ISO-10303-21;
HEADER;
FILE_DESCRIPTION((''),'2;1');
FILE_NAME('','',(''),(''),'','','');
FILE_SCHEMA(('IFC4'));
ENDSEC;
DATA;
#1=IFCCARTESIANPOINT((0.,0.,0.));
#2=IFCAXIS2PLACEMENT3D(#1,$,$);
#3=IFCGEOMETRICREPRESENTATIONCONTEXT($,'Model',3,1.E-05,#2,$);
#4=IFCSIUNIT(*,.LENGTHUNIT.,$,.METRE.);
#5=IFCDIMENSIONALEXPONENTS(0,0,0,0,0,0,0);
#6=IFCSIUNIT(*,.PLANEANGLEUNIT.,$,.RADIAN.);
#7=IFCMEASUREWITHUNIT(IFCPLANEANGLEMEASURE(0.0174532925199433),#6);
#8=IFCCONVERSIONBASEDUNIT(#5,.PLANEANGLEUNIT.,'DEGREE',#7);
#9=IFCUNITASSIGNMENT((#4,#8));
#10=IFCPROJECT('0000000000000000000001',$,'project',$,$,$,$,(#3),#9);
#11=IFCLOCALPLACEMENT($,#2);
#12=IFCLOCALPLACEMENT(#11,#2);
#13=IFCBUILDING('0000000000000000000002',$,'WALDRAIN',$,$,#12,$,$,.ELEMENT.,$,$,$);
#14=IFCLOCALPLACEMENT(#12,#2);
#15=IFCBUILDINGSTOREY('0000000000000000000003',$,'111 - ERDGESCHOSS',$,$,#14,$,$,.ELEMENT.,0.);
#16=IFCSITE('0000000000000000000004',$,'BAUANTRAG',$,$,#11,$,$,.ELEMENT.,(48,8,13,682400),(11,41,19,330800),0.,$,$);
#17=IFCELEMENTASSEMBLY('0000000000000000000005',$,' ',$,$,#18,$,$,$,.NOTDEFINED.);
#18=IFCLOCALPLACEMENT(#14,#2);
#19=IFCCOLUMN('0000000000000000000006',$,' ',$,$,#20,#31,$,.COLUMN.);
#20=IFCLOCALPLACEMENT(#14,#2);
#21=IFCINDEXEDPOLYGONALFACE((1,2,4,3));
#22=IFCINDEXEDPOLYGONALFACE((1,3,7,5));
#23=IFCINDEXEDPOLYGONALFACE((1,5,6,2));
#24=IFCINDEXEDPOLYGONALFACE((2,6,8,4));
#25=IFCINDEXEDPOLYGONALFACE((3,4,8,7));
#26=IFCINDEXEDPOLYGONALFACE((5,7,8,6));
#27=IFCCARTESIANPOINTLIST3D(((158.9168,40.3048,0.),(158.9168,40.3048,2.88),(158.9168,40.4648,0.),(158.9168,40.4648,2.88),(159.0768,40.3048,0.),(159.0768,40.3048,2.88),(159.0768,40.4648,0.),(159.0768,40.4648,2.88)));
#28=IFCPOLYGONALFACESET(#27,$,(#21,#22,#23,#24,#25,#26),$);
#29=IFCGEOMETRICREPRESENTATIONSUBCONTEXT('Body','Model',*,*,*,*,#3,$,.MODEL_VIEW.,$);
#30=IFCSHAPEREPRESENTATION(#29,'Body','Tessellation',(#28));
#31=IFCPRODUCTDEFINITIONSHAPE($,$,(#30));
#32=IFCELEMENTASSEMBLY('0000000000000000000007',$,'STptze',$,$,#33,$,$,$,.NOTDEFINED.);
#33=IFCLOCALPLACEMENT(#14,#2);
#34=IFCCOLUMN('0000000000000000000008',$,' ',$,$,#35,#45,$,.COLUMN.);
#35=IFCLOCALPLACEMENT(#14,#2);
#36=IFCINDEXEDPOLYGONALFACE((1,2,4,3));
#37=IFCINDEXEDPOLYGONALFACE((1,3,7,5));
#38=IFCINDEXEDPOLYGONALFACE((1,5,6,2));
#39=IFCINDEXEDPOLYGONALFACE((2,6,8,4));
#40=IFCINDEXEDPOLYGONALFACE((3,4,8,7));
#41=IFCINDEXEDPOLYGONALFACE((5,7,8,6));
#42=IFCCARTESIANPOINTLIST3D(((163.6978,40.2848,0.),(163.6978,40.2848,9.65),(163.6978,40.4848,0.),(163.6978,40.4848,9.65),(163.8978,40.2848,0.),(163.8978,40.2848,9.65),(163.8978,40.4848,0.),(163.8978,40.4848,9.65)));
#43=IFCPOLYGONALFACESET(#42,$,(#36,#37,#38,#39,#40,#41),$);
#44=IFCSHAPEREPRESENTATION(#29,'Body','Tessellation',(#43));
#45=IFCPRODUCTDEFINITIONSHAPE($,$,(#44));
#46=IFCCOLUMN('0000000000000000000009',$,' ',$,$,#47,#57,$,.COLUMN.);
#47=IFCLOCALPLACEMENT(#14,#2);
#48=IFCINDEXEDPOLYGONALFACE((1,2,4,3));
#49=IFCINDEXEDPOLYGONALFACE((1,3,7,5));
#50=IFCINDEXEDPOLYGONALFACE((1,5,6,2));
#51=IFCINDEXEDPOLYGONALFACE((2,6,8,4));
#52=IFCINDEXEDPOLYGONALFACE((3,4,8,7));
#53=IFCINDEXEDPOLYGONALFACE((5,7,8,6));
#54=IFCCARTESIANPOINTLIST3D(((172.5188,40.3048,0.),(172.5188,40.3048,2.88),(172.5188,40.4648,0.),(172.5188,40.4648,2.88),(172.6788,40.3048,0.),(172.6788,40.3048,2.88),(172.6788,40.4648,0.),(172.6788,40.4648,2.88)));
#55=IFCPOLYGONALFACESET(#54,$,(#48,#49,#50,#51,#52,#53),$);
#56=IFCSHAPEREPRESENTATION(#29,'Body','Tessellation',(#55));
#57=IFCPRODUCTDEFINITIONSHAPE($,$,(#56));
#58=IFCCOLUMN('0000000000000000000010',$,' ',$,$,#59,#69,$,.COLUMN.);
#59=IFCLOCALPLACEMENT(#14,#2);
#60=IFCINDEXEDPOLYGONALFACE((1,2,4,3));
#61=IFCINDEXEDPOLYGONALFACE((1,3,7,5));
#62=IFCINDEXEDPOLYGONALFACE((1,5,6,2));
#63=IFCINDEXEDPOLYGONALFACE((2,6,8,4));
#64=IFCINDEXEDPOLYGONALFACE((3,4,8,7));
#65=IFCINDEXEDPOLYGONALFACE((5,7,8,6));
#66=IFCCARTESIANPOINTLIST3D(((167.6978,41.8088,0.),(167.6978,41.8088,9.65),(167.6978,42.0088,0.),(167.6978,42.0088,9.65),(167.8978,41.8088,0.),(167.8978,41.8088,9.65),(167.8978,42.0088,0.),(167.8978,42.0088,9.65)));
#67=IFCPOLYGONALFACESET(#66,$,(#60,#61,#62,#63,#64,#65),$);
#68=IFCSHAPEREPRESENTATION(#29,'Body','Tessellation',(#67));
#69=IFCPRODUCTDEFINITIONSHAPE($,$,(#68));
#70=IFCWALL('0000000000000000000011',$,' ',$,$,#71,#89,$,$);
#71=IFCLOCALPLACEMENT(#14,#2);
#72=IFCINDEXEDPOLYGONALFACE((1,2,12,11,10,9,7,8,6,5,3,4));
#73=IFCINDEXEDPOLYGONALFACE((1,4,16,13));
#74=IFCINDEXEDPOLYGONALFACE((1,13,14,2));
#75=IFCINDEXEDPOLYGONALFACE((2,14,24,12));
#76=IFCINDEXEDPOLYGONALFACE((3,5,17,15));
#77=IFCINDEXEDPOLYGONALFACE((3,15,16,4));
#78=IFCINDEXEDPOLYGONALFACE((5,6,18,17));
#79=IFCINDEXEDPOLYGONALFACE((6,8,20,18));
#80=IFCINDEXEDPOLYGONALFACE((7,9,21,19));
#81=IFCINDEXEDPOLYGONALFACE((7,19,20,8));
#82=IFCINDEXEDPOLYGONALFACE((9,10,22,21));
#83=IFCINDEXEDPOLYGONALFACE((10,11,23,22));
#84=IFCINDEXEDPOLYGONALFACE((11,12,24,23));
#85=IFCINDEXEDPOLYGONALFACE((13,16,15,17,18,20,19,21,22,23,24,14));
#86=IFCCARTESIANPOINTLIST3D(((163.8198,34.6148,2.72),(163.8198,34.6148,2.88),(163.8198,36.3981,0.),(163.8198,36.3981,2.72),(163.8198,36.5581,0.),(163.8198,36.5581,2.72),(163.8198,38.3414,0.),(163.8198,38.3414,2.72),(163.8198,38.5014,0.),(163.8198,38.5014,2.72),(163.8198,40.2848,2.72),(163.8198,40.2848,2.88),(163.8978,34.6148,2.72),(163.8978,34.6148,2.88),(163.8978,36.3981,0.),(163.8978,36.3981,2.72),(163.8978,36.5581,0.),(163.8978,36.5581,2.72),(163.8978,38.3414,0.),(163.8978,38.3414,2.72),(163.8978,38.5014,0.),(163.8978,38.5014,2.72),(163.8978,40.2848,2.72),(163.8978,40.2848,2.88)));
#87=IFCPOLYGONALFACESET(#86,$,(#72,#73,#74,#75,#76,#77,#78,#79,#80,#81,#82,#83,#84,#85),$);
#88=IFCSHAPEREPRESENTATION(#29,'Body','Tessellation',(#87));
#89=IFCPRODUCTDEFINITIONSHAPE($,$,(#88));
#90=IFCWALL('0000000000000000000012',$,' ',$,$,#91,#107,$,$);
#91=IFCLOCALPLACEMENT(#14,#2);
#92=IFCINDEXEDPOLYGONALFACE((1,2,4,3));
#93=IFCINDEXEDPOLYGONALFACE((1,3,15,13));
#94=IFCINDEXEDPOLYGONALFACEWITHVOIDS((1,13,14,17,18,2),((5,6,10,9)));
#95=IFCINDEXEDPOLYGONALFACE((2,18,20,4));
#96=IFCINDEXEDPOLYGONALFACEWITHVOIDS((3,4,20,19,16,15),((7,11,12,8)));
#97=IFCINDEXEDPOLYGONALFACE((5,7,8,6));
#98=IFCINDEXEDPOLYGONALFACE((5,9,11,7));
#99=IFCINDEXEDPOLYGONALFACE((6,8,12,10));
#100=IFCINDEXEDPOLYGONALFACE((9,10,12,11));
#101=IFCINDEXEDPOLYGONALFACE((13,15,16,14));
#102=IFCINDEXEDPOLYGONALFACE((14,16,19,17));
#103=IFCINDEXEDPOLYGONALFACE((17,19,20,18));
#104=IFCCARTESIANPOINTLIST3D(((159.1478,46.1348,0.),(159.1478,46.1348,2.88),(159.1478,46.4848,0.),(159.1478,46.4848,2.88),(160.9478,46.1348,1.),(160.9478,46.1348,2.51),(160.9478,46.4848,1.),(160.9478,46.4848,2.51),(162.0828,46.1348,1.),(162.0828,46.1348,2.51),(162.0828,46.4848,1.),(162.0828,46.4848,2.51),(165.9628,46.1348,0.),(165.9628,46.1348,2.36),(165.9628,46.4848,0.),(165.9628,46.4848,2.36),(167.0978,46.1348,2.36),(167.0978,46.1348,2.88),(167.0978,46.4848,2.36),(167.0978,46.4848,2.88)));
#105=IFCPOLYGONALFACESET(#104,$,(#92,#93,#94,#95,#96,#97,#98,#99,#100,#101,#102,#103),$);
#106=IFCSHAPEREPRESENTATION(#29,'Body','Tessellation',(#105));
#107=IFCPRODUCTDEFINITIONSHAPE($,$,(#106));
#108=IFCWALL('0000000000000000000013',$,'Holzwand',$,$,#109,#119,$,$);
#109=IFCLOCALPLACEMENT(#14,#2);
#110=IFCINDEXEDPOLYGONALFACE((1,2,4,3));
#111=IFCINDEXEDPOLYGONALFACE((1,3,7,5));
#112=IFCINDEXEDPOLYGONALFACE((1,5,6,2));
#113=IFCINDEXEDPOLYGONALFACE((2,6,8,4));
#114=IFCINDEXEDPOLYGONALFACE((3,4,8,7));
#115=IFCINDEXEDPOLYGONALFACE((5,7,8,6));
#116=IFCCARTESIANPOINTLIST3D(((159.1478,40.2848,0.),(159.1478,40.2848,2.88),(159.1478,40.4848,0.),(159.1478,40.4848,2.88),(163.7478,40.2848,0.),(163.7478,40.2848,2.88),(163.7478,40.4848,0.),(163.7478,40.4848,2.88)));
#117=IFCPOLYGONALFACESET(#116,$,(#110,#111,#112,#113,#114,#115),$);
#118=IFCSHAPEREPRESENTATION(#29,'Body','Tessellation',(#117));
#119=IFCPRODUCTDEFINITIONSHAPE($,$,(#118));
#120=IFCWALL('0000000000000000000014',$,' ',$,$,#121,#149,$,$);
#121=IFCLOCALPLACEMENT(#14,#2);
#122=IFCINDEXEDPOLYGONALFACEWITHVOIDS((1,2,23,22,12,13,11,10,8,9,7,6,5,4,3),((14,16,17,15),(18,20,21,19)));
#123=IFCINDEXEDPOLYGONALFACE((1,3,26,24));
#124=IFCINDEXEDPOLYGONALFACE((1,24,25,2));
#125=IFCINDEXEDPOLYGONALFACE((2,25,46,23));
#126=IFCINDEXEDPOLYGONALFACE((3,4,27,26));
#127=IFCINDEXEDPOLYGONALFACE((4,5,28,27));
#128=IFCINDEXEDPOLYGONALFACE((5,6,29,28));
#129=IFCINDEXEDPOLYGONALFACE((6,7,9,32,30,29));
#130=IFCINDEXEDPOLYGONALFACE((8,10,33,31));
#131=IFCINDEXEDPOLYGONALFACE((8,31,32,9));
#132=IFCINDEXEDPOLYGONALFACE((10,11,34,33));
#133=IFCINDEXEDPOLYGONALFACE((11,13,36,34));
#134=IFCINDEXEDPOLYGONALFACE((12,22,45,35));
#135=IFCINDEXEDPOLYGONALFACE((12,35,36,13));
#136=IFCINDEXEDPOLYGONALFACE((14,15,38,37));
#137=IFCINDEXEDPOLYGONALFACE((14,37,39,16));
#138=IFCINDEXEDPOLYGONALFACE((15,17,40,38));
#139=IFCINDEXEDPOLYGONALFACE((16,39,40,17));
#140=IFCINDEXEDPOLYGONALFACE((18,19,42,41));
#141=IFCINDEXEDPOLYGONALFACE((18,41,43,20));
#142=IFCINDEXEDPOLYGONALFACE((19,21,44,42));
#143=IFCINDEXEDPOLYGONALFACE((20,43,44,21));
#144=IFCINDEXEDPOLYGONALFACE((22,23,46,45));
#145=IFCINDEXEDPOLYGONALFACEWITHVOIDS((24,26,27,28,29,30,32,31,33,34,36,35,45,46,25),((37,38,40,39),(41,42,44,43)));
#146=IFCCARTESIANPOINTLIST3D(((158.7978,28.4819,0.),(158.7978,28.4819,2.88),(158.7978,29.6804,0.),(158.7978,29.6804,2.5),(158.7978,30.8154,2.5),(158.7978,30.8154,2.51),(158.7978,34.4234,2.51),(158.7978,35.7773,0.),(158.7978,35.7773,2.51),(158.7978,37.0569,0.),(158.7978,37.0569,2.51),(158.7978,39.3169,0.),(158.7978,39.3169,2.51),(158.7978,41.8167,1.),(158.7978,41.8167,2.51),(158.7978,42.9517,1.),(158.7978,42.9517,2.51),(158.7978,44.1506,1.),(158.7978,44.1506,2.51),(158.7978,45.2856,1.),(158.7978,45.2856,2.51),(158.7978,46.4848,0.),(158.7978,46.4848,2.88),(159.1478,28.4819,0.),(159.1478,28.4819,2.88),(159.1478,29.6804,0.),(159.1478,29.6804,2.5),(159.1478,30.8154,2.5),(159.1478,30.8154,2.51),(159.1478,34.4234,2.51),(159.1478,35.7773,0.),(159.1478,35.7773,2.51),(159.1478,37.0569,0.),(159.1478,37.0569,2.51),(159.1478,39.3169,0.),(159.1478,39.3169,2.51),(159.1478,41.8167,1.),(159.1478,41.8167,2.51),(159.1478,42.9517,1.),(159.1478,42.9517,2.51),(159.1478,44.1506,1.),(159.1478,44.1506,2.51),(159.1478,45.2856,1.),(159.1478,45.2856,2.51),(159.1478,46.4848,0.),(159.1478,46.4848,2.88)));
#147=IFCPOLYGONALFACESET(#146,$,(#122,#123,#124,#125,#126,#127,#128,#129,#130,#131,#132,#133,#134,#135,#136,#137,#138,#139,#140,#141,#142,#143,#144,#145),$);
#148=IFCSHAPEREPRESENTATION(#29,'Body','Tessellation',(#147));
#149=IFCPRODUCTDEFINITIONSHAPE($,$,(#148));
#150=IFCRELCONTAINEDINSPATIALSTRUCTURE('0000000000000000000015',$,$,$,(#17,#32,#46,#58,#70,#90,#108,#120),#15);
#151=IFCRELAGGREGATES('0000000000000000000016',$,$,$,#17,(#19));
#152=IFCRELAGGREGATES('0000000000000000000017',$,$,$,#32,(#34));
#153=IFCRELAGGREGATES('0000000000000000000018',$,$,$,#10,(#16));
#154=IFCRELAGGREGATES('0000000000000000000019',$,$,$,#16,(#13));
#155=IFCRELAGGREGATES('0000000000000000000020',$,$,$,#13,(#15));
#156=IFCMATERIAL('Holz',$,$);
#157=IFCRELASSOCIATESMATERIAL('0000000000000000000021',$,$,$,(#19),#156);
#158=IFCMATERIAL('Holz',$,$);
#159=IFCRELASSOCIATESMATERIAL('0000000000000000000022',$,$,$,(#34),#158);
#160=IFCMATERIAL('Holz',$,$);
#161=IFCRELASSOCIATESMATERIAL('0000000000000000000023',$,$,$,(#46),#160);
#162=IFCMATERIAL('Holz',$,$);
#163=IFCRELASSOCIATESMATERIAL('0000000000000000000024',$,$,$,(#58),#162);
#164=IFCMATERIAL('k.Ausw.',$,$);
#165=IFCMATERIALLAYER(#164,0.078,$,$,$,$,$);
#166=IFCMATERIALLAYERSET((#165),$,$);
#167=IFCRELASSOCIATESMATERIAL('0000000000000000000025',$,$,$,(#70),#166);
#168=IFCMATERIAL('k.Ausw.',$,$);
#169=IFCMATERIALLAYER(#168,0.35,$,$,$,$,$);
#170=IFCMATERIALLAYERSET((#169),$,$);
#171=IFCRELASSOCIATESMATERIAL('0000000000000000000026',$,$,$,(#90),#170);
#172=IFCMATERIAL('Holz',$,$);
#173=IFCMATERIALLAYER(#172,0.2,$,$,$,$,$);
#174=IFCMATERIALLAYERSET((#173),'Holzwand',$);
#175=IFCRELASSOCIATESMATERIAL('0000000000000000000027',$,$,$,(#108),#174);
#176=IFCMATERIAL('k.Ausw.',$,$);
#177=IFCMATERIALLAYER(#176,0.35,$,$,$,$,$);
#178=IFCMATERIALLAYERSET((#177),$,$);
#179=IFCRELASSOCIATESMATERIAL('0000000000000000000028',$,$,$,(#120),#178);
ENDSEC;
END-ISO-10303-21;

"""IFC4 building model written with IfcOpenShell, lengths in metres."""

from ifc_helpers import new_model, entity, si_unit, converted_unit, frame, frame_2d, origin, origin_with_axes, place, context, subcontext, project, spatial, polyline, rectangle, outline, extrude, material, layer, layer_set, layer_usage, element, aggregate, save


model = new_model("IFC4")

# Units and contexts
model_context = context("Model", 3, precision=1e-05, world=origin())
body_context = subcontext(model_context, "Body", "Model", "MODEL_VIEW")
ifc_project = project(units=[si_unit("LENGTHUNIT", "METRE"), converted_unit("PLANEANGLEUNIT", "DEGREE", entity("IfcPlaneAngleMeasure", 0.0174532925199433), si_unit("PLANEANGLEUNIT", "RADIAN"), dimensions=[0, 0, 0, 0, 0, 0, 0])], contexts=[model_context])

# Site, building, storey
site_placement = place(None, origin())
site = spatial("IfcSite", under=ifc_project, at=site_placement, Name="BAUANTRAG", CompositionType="ELEMENT", RefLatitude=(48, 8, 13, 682400), RefLongitude=(11, 41, 19, 330800), RefElevation=0.0)
building_placement = place(site_placement, origin())
building = spatial("IfcBuilding", under=site, at=building_placement, Name="WALDRAIN", CompositionType="ELEMENT")
storey_placement = place(building_placement, origin())
storey = spatial("IfcBuildingStorey", under=building, at=storey_placement, Name="111 - ERDGESCHOSS", CompositionType="ELEMENT", Elevation=0.0)

# Element assemblies, columns
assembly_1_placement = place(storey_placement, origin())
assembly_1 = element("IfcElementAssembly", 1, at=assembly_1_placement, inside=storey, Name=" ", PredefinedType="NOTDEFINED")
ifc_material_1 = material(Name="Holz")
column_1_placement = place(assembly_1_placement, frame((158.9168, 40.3048, 0.0)))
column_1 = element("IfcColumn", 2, at=column_1_placement, material=ifc_material_1, Name=" ", PredefinedType="COLUMN", context=body_context, shape_type="SweptSolid", body=[
    extrude(rectangle(XDim=0.16, YDim=0.16, at=frame_2d((0.08, 0.08), x_axis=(1.0, 0.0))), origin_with_axes(), (0.0, 0.0, 1.0), 2.88),
])
aggregate(assembly_1, [column_1])
assembly_2_placement = place(storey_placement, origin())
assembly_2 = element("IfcElementAssembly", 3, at=assembly_2_placement, inside=storey, Name="STptze", PredefinedType="NOTDEFINED")
ifc_material_2 = material(Name="Holz")
column_2_placement = place(assembly_2_placement, frame((163.6978, 40.2848, 0.0)))
column_2 = element("IfcColumn", 4, at=column_2_placement, material=ifc_material_2, Name=" ", PredefinedType="COLUMN", context=body_context, shape_type="SweptSolid", body=[
    extrude(rectangle(XDim=0.2, YDim=0.2, at=frame_2d((0.1, 0.1), x_axis=(1.0, 0.0))), origin_with_axes(), (0.0, 0.0, 1.0), 9.65),
])
aggregate(assembly_2, [column_2])

# Columns
ifc_material_3 = material(Name="Holz")
column_3_placement = place(storey_placement, frame((172.5188, 40.3048, 0.0)))
element("IfcColumn", 5, at=column_3_placement, inside=storey, material=ifc_material_3, Name=" ", PredefinedType="COLUMN", context=body_context, shape_type="SweptSolid", body=[
    extrude(rectangle(XDim=0.16, YDim=0.16, at=frame_2d((0.08, 0.08), x_axis=(1.0, 0.0))), origin_with_axes(), (0.0, 0.0, 1.0), 2.88),
])
ifc_material_4 = material(Name="Holz")
column_4_placement = place(storey_placement, frame((167.6978, 41.8088, 0.0)))
element("IfcColumn", 6, at=column_4_placement, inside=storey, material=ifc_material_4, Name=" ", PredefinedType="COLUMN", context=body_context, shape_type="SweptSolid", body=[
    extrude(rectangle(XDim=0.2, YDim=0.2, at=frame_2d((0.1, 0.1), x_axis=(1.0, 0.0))), origin_with_axes(), (0.0, 0.0, 1.0), 9.65),
])

# Walls, openings
ifc_material_5 = material(Name="k.Ausw.")
ifc_layer_1 = layer(ifc_material_5, 0.078)
ifc_layer_set_1 = layer_set([ifc_layer_1])
ifc_layer_usage_1 = layer_usage(ifc_layer_set_1, "AXIS2", "POSITIVE", 0.0)
wall_1_placement = place(storey_placement, frame((163.8198, 40.2848, 0.0), z_axis=(0.0, 0.0, 1.0), x_axis=(0.0, -1.0, 0.0)))
wall_1 = element("IfcWall", 7, at=wall_1_placement, inside=storey, material=ifc_layer_usage_1, Name=" ", context=body_context, shape_type="SweptSolid", body=[
    extrude(rectangle(XDim=5.67, YDim=0.078, at=frame_2d((2.835, 0.039), x_axis=(1.0, 0.0))), origin_with_axes(), (0.0, 0.0, 1.0), 2.88),
])
opening_1_placement = place(wall_1_placement, frame((1.9434, 0.0, 0.0), z_axis=(0.0, 1.0, 0.0), x_axis=(0.0, 0.0, 1.0)))
element("IfcOpeningElement", 8, at=opening_1_placement, cuts=wall_1, ObjectType="Opening", context=body_context, shape_type="SweptSolid", body=[
    extrude(outline(polyline([(0.0, 1.7833), (2.72, 1.7833), (2.72, 0.0), (0.0, 0.0), (0.0, 1.7833)])), origin_with_axes(), (0.0, 0.0, 1.0), 0.078),
])
opening_2_placement = place(wall_1_placement, frame((3.8867, 0.0, 0.0), z_axis=(0.0, 1.0, 0.0), x_axis=(0.0, 0.0, 1.0)))
element("IfcOpeningElement", 9, at=opening_2_placement, cuts=wall_1, ObjectType="Opening", context=body_context, shape_type="SweptSolid", body=[
    extrude(outline(polyline([(0.0, 1.7833), (2.72, 1.7833), (2.72, 0.0), (0.0, 0.0), (0.0, 1.7833)])), origin_with_axes(), (0.0, 0.0, 1.0), 0.078),
])
opening_3_placement = place(wall_1_placement, frame((0.0, 0.0, 0.0), z_axis=(0.0, 1.0, 0.0), x_axis=(0.0, 0.0, 1.0)))
element("IfcOpeningElement", 10, at=opening_3_placement, cuts=wall_1, ObjectType="Opening", context=body_context, shape_type="SweptSolid", body=[
    extrude(outline(polyline([(0.0, 1.7834), (2.72, 1.7834), (2.72, 0.0), (0.0, 0.0), (0.0, 1.7834)])), origin_with_axes(), (0.0, 0.0, 1.0), 0.078),
])
ifc_material_6 = material(Name="k.Ausw.")
ifc_layer_2 = layer(ifc_material_6, 0.35)
ifc_layer_set_2 = layer_set([ifc_layer_2])
ifc_layer_usage_2 = layer_usage(ifc_layer_set_2, "AXIS2", "POSITIVE", 0.0)
wall_2_placement = place(storey_placement, frame((167.0978, 46.4848, 0.0), z_axis=(0.0, 0.0, 1.0), x_axis=(-1.0, 0.0, 0.0)))
wall_2 = element("IfcWall", 11, at=wall_2_placement, inside=storey, material=ifc_layer_usage_2, Name=" ", context=body_context, shape_type="SweptSolid", body=[
    extrude(rectangle(XDim=7.95, YDim=0.35, at=frame_2d((3.975, 0.175), x_axis=(1.0, 0.0))), origin_with_axes(), (0.0, 0.0, 1.0), 2.88),
])
opening_4_placement = place(wall_2_placement, frame((6.15, 0.35, 1.0), z_axis=(0.0, -1.0, 0.0), x_axis=(0.0, 0.0, 1.0)))
element("IfcOpeningElement", 12, at=opening_4_placement, cuts=wall_2, ObjectType="Opening", context=body_context, shape_type="SweptSolid", body=[
    extrude(outline(polyline([(0.0, 1.135), (1.51, 1.135), (1.51, 0.0), (0.0, 0.0), (0.0, 1.135)])), origin_with_axes(), (0.0, 0.0, 1.0), 0.35),
])
opening_5_placement = place(wall_2_placement, frame((0.0, 0.0, -0.15), z_axis=(0.0, 1.0, 0.0), x_axis=(0.0, 0.0, 1.0)))
element("IfcOpeningElement", 13, at=opening_5_placement, cuts=wall_2, ObjectType="Opening", context=body_context, shape_type="SweptSolid", body=[
    extrude(outline(polyline([(0.0, 1.135), (2.51, 1.135), (2.51, 0.0), (0.0, 0.0), (0.0, 1.135)])), origin_with_axes(), (0.0, 0.0, 1.0), 0.35),
])

# Wall
ifc_material_7 = material(Name="Holz")
ifc_layer_3 = layer(ifc_material_7, 0.2)
ifc_layer_set_3 = layer_set([ifc_layer_3], Name="Holzwand")
ifc_layer_usage_3 = layer_usage(ifc_layer_set_3, "AXIS2", "POSITIVE", 0.0)
wall_3_placement = place(storey_placement, frame((163.7478, 40.4848, 0.0), z_axis=(0.0, 0.0, 1.0), x_axis=(-1.0, 0.0, 0.0)))
element("IfcWall", 14, at=wall_3_placement, inside=storey, material=ifc_layer_usage_3, Name="Holzwand", context=body_context, shape_type="SweptSolid", body=[
    extrude(rectangle(XDim=4.6, YDim=0.2, at=frame_2d((2.3, 0.1), x_axis=(1.0, 0.0))), origin_with_axes(), (0.0, 0.0, 1.0), 2.88),
])

# Wall, openings
ifc_material_8 = material(Name="k.Ausw.")
ifc_layer_4 = layer(ifc_material_8, 0.35)
ifc_layer_set_4 = layer_set([ifc_layer_4])
ifc_layer_usage_4 = layer_usage(ifc_layer_set_4, "AXIS2", "POSITIVE", 0.0)
wall_4_placement = place(storey_placement, frame((158.7978, 46.4848, 0.0), z_axis=(0.0, 0.0, 1.0), x_axis=(0.0, -1.0, 0.0)))
wall_4 = element("IfcWall", 15, at=wall_4_placement, inside=storey, material=ifc_layer_usage_4, Name=" ", context=body_context, shape_type="SweptSolid", body=[
    extrude(rectangle(XDim=18.0029, YDim=0.35, at=frame_2d((9.0014, 0.175), x_axis=(1.0, 0.0))), origin_with_axes(), (0.0, 0.0, 1.0), 2.88),
])
opening_6_placement = place(wall_4_placement, frame((1.1992, 0.0, 1.0), z_axis=(0.0, 1.0, 0.0), x_axis=(0.0, 0.0, 1.0)))
element("IfcOpeningElement", 16, at=opening_6_placement, cuts=wall_4, ObjectType="Opening", context=body_context, shape_type="SweptSolid", body=[
    extrude(outline(polyline([(0.0, 1.135), (1.51, 1.135), (1.51, 0.0), (0.0, 0.0), (0.0, 1.135)])), origin_with_axes(), (0.0, 0.0, 1.0), 0.35),
])
opening_7_placement = place(wall_4_placement, frame((3.5331, 0.0, 1.0), z_axis=(0.0, 1.0, 0.0), x_axis=(0.0, 0.0, 1.0)))
element("IfcOpeningElement", 17, at=opening_7_placement, cuts=wall_4, ObjectType="Opening", context=body_context, shape_type="SweptSolid", body=[
    extrude(outline(polyline([(0.0, 1.135), (1.51, 1.135), (1.51, 0.0), (0.0, 0.0), (0.0, 1.135)])), origin_with_axes(), (0.0, 0.0, 1.0), 0.35),
])
opening_8_placement = place(wall_4_placement, frame((7.1679, 0.0, 0.0), z_axis=(0.0, 1.0, 0.0), x_axis=(0.0, 0.0, 1.0)))
element("IfcOpeningElement", 18, at=opening_8_placement, cuts=wall_4, ObjectType="Opening", context=body_context, shape_type="SweptSolid", body=[
    extrude(outline(polyline([(0.0, 2.26), (2.51, 2.26), (2.51, 0.0), (0.0, 0.0), (0.0, 2.26)])), origin_with_axes(), (0.0, 0.0, 1.0), 0.35),
])
opening_9_placement = place(wall_4_placement, frame((10.7075, 0.0, 0.0), z_axis=(0.0, 1.0, 0.0), x_axis=(0.0, 0.0, 1.0)))
element("IfcOpeningElement", 19, at=opening_9_placement, cuts=wall_4, ObjectType="Opening", context=body_context, shape_type="SweptSolid", body=[
    extrude(outline(polyline([(0.0, 1.3539), (2.51, 1.3539), (2.51, 0.0), (0.0, 0.0), (0.0, 1.3539)])), origin_with_axes(), (0.0, 0.0, 1.0), 0.35),
])
opening_10_placement = place(wall_4_placement, frame((15.6694, 0.0, 0.0), z_axis=(0.0, 1.0, 0.0), x_axis=(0.0, 0.0, 1.0)))
element("IfcOpeningElement", 20, at=opening_10_placement, cuts=wall_4, ObjectType="Opening", context=body_context, shape_type="SweptSolid", body=[
    extrude(outline(polyline([(0.0, 1.135), (2.5, 1.135), (2.5, 0.0), (0.0, 0.0), (0.0, 1.135)])), origin_with_axes(), (0.0, 0.0, 1.0), 0.35),
])
opening_11_placement = place(wall_4_placement, frame((12.0614, 0.0, 0.0), z_axis=(0.0, 1.0, 0.0), x_axis=(0.0, 0.0, 1.0)))
element("IfcOpeningElement", 21, at=opening_11_placement, cuts=wall_4, ObjectType="Opening", context=body_context, shape_type="SweptSolid", body=[
    extrude(outline(polyline([(0.0, 3.608), (2.51, 3.608), (2.51, 0.0), (0.0, 0.0), (0.0, 3.608)])), origin_with_axes(), (0.0, 0.0, 1.0), 0.35),
])

save(model, "model.ifc")
